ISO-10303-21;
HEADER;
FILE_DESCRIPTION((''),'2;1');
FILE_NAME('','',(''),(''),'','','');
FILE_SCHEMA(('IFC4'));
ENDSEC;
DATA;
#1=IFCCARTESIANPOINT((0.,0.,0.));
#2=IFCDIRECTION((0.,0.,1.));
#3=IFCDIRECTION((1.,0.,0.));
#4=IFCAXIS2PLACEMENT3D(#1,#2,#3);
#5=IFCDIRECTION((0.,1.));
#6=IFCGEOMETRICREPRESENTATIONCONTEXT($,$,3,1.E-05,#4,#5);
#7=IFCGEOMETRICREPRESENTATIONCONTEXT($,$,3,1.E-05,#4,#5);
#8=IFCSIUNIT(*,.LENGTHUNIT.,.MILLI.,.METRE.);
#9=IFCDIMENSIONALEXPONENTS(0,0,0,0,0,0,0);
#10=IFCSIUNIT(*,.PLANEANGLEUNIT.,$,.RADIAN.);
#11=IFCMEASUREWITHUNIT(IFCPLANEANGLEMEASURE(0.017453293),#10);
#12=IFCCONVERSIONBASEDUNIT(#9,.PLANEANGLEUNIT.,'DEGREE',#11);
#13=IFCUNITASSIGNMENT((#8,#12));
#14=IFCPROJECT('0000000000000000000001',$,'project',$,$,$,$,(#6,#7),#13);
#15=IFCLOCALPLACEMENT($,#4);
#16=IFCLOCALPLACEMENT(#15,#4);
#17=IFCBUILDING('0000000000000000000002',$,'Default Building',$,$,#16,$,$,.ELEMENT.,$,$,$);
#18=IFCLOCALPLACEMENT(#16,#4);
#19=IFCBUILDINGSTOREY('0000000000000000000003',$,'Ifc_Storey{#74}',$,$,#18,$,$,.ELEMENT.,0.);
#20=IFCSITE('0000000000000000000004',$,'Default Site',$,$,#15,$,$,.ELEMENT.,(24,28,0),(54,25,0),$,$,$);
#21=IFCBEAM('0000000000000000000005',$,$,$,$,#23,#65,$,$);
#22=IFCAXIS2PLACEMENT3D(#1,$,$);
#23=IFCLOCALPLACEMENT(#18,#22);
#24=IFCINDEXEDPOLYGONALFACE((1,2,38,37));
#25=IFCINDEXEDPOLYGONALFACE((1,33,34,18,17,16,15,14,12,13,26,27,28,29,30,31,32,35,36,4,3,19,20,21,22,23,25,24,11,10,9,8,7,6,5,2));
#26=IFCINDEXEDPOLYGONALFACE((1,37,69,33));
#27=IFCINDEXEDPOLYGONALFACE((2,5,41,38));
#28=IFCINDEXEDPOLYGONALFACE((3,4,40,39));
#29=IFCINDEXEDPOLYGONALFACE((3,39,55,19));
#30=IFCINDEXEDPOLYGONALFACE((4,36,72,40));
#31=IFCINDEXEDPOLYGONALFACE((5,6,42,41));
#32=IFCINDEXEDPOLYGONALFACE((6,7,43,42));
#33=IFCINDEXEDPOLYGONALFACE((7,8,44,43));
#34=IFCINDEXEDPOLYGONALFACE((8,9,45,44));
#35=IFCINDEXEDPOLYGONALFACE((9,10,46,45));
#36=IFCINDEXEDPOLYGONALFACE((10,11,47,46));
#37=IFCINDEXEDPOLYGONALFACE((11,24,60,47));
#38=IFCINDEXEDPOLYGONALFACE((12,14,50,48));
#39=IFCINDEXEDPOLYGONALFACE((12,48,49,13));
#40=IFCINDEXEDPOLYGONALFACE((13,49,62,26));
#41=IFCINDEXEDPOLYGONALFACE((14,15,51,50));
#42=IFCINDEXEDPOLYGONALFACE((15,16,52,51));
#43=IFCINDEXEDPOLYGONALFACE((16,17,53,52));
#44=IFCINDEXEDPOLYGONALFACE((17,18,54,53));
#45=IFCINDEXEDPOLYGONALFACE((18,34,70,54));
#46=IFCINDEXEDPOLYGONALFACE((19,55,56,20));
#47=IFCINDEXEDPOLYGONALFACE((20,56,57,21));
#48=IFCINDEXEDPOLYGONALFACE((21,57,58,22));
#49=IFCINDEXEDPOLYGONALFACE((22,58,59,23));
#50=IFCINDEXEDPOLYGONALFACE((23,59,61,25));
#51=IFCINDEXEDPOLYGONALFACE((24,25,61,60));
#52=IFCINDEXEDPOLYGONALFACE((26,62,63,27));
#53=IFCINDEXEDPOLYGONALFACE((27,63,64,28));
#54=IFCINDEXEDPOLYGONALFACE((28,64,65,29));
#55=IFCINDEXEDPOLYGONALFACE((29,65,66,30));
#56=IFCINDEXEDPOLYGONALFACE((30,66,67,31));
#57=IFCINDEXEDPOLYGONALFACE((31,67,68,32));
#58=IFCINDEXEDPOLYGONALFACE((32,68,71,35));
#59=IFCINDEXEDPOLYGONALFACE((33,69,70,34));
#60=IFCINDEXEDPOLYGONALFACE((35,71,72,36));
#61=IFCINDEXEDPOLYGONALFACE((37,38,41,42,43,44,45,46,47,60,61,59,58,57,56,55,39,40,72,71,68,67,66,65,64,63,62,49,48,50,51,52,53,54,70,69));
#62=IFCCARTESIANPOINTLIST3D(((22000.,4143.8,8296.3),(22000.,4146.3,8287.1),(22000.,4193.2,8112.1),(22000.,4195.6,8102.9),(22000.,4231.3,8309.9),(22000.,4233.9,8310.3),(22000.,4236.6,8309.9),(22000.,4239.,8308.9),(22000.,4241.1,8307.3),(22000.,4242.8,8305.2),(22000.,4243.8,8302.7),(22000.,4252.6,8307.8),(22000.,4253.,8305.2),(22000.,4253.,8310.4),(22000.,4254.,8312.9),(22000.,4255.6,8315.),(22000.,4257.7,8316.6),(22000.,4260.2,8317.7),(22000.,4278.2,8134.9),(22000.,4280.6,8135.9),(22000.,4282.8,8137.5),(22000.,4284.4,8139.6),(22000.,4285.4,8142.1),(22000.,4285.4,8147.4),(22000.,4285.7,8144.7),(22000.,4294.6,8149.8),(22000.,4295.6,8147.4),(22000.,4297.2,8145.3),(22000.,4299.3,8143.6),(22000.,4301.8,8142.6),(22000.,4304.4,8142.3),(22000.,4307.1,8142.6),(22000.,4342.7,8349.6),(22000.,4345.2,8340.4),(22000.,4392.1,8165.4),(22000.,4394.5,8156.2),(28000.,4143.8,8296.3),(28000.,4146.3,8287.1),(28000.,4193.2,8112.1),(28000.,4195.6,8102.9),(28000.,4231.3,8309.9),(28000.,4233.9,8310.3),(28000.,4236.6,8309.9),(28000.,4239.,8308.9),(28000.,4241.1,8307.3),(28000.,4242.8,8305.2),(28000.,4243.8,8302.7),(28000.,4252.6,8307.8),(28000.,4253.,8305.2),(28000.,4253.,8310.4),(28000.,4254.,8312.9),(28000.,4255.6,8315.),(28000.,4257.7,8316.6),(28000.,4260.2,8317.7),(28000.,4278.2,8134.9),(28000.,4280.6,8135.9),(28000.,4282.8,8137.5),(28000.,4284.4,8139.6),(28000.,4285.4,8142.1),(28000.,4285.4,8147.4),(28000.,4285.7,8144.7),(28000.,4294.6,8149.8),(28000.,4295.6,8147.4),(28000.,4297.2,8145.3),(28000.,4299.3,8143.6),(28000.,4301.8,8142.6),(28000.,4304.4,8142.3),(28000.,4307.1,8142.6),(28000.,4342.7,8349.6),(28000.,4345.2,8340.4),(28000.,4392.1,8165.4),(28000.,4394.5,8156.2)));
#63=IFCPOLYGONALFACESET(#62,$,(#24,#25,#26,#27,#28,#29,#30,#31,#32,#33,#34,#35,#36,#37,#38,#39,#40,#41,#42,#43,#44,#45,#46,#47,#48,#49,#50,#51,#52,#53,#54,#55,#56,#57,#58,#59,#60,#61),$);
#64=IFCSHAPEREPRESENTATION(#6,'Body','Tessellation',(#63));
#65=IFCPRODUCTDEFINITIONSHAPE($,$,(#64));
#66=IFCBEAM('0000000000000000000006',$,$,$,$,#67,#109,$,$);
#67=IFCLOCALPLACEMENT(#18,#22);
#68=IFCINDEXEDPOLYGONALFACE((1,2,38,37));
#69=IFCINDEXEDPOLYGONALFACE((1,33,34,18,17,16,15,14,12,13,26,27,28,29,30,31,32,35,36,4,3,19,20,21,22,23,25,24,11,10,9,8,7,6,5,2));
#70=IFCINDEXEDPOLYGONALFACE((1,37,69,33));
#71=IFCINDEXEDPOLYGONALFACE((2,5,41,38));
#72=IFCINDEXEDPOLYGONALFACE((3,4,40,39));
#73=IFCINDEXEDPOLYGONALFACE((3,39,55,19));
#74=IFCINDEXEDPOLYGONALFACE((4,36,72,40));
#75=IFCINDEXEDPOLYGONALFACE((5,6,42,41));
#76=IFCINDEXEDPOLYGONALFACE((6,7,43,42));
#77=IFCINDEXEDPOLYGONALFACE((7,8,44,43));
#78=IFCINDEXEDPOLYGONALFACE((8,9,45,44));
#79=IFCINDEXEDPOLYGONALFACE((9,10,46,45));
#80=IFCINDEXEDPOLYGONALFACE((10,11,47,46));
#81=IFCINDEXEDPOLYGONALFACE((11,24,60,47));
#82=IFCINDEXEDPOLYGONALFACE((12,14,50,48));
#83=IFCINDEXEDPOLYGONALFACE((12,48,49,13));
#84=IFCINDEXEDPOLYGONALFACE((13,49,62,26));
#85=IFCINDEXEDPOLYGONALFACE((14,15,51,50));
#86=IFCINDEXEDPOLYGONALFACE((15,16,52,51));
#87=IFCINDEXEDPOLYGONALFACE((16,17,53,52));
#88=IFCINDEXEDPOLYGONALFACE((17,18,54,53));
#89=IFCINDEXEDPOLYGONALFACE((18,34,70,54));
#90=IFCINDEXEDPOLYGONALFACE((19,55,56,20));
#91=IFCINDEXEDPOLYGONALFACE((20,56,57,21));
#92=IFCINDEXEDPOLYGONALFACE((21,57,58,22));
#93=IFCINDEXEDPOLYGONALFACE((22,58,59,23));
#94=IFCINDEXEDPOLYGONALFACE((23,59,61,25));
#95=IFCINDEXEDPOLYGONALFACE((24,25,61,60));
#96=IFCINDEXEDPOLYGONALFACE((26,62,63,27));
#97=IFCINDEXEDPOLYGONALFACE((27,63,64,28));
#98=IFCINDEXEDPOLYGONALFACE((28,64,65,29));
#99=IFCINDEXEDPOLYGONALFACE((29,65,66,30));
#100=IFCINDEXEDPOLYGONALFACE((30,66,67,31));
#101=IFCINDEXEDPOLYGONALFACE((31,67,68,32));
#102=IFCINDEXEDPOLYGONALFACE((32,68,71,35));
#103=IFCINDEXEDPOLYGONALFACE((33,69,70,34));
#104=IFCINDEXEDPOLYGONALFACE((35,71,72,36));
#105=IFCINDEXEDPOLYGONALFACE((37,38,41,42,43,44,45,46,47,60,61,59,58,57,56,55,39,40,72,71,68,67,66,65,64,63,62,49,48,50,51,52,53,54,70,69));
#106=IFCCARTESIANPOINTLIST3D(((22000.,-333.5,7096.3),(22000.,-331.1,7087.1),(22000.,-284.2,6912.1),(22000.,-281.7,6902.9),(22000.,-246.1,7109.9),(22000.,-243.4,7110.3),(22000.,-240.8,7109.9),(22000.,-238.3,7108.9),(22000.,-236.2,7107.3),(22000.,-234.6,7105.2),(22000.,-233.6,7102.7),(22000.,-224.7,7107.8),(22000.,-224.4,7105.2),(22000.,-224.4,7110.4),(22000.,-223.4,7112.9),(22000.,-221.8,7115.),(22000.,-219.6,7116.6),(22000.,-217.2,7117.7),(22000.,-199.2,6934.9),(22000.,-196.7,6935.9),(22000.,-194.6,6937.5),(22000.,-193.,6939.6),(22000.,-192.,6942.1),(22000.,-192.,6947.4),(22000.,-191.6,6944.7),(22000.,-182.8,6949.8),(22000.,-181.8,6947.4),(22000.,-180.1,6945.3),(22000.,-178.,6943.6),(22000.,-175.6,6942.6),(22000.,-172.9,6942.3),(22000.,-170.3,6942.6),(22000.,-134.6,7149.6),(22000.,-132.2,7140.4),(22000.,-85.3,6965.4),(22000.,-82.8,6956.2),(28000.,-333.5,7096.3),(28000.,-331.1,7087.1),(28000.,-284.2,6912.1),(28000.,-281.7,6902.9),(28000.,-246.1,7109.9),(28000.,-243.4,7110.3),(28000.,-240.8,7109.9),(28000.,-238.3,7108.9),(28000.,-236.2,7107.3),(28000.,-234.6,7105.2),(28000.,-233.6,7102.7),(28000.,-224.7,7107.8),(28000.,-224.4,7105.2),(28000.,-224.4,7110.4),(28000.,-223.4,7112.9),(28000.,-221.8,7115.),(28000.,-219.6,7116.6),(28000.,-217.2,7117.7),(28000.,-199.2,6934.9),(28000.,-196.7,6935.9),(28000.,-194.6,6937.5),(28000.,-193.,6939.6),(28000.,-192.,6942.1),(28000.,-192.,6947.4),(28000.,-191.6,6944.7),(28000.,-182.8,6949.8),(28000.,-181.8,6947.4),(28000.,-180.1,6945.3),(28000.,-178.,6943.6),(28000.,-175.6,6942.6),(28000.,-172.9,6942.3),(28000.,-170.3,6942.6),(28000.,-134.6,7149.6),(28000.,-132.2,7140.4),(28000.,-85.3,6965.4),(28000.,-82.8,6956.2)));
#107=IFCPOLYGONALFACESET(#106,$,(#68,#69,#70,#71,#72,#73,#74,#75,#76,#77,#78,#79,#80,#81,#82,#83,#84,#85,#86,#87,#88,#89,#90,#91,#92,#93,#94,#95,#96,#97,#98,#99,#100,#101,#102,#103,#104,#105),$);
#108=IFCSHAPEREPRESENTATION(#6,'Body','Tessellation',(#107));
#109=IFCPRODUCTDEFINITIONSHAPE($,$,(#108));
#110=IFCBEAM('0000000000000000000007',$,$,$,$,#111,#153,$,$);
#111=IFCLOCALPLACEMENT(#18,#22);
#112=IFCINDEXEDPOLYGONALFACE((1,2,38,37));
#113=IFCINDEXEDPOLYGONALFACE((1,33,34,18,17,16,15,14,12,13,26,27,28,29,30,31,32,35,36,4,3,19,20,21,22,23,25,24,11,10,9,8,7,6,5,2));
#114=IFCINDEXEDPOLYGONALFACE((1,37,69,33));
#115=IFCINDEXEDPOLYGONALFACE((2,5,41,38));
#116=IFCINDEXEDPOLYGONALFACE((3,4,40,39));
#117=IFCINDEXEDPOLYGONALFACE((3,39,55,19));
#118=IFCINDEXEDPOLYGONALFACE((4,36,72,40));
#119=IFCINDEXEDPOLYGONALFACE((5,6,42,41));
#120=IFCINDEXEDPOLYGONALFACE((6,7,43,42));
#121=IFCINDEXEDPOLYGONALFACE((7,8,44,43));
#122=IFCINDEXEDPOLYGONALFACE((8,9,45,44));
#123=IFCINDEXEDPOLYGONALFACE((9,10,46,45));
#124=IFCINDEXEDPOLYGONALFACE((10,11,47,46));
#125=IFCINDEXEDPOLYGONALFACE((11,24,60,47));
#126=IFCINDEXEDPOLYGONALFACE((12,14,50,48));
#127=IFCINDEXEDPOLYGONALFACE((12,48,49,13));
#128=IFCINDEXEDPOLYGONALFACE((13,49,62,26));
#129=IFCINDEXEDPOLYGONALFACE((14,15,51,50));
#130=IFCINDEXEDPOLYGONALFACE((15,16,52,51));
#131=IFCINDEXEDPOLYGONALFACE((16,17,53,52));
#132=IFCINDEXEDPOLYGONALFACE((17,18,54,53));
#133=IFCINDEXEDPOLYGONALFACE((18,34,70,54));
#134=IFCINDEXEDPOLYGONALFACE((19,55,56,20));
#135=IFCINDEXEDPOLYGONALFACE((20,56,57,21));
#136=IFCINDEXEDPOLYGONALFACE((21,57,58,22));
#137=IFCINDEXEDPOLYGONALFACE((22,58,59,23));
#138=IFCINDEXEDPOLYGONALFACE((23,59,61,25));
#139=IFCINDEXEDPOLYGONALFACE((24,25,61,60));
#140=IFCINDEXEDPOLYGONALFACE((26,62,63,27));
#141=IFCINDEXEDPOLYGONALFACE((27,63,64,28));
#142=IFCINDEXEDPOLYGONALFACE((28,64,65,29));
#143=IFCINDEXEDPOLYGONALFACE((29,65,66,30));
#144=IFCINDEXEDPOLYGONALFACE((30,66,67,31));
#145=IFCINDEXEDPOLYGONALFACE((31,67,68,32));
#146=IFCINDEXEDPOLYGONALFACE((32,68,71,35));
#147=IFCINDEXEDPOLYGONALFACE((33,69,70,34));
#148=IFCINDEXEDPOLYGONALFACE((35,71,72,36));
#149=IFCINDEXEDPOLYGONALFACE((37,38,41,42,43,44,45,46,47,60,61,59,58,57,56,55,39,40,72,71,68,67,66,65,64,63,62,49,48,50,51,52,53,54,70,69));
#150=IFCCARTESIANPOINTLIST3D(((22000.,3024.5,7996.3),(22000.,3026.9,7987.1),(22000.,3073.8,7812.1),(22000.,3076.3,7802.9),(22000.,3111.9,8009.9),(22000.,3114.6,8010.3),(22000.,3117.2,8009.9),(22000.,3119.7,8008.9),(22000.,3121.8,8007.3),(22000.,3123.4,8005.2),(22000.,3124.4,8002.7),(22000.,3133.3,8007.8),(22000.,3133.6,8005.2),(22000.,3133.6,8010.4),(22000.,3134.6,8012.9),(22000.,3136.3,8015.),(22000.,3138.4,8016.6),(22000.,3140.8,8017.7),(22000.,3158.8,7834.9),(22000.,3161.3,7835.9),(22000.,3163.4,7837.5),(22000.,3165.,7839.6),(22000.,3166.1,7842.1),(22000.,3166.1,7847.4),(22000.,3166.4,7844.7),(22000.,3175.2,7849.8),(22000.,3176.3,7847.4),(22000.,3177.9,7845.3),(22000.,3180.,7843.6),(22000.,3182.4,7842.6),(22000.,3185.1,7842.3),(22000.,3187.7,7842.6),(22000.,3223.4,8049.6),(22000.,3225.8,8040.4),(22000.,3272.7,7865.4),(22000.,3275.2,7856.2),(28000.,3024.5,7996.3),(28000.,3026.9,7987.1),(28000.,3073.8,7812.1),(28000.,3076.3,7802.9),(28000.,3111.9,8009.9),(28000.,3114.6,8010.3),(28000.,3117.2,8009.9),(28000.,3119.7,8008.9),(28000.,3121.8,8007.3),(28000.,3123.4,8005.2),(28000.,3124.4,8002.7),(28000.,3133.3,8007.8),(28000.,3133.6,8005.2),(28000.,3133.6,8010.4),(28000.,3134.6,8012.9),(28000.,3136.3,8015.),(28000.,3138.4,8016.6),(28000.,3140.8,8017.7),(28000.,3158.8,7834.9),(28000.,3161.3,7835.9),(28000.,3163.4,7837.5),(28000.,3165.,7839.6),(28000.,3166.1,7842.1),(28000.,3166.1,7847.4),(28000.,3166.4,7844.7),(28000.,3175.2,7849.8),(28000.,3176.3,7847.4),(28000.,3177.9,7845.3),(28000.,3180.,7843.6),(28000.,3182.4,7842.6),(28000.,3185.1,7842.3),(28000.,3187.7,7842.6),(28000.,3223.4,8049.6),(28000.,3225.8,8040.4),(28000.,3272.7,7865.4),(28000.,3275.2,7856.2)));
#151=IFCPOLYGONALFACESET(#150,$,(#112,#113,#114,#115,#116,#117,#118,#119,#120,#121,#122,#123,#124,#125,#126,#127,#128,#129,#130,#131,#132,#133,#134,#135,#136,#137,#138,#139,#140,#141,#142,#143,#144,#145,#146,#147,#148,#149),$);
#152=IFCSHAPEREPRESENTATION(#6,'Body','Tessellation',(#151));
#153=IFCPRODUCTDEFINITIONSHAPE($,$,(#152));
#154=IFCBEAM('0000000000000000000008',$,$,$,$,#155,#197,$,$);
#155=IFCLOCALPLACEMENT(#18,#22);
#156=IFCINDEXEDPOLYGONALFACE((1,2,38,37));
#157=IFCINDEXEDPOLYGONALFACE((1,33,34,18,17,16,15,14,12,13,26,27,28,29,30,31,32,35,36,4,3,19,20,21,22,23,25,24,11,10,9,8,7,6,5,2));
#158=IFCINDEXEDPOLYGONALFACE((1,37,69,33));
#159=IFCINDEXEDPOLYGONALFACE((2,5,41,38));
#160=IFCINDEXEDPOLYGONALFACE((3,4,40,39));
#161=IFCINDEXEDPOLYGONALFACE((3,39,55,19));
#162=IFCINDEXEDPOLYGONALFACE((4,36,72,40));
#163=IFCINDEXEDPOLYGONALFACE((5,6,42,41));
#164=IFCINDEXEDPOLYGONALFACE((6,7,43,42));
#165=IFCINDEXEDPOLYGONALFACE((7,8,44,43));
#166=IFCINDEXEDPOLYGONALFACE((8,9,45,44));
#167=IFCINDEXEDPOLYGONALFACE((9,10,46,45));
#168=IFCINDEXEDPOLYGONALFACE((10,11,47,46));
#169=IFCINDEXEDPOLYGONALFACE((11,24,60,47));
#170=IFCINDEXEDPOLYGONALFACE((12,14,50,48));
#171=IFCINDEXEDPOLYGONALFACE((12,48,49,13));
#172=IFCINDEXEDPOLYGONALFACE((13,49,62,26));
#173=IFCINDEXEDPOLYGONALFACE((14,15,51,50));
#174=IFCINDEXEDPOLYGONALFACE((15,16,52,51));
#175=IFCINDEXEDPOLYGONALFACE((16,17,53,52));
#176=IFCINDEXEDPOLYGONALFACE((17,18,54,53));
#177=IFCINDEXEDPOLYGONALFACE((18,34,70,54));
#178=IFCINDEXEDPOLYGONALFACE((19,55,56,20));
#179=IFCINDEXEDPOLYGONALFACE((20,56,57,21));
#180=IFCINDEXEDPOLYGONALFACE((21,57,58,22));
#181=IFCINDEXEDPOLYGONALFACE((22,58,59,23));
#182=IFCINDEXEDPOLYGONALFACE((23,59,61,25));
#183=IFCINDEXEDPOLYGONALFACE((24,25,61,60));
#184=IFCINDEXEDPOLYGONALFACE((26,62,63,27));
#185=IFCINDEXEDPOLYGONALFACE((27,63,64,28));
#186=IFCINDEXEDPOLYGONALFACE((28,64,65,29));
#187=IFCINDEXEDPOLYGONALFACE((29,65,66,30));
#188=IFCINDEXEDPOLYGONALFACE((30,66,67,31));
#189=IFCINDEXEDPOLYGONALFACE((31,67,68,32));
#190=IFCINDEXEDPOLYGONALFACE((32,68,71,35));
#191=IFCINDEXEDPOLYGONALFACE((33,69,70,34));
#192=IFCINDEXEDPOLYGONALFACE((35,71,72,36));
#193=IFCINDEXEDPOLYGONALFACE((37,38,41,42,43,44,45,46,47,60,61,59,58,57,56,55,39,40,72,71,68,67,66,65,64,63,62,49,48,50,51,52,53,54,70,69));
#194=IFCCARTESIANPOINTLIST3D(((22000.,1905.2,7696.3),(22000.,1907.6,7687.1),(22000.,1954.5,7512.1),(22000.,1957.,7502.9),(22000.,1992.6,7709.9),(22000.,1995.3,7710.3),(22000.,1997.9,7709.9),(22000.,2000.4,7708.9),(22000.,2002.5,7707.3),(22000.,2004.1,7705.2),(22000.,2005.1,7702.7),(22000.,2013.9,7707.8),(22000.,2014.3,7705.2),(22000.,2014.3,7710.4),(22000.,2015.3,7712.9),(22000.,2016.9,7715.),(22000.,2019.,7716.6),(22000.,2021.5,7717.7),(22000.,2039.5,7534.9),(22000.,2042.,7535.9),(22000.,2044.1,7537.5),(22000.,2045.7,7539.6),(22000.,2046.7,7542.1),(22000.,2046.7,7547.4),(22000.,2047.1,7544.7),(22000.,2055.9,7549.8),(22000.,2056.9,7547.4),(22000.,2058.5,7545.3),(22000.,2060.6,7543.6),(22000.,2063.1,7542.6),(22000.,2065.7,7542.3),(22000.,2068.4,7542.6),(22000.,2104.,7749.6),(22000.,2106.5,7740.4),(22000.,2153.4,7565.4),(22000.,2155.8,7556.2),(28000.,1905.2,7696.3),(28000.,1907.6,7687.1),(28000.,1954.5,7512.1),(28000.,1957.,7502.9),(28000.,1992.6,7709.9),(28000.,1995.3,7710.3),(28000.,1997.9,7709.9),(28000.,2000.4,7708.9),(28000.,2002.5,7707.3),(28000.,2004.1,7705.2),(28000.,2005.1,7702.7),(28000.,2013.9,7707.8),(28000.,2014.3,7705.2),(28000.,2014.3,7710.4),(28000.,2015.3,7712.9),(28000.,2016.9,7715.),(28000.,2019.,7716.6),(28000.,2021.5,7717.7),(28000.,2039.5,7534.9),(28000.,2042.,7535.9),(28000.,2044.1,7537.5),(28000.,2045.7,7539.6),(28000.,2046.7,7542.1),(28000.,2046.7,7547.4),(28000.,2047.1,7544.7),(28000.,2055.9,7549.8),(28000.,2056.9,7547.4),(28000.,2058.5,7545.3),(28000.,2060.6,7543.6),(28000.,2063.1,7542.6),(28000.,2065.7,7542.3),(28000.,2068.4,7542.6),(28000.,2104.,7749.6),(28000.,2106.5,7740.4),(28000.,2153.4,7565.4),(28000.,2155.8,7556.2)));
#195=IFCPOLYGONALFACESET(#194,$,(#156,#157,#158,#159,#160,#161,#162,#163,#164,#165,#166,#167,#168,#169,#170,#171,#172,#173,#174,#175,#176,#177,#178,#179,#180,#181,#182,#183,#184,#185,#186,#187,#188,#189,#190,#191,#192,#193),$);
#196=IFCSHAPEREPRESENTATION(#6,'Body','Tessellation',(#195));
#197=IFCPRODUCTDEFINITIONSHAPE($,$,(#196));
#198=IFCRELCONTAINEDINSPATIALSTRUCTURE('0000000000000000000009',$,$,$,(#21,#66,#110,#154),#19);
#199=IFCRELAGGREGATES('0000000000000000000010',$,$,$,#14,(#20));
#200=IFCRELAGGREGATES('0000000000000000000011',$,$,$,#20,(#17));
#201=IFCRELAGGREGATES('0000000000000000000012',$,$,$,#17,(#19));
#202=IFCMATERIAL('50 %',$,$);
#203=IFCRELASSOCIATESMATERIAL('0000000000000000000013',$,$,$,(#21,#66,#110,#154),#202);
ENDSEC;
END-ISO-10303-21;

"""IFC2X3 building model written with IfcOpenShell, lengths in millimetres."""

from ifc_helpers import new_model, entity, si_unit, converted_unit, direction, frame, origin_with_axes, origin_2d_with_axis, place, context, project, spatial, i_section, extrude, material, element, save


model = new_model("IFC2X3")

# Units and contexts
context_of_model_1 = context(None, 3, precision=1e-05, world=origin_with_axes(), true_north=direction((0.0, 1.0)))
context_of_model_2 = context(None, 3, precision=1e-05, world=origin_with_axes(), true_north=direction((0.0, 1.0)))
ifc_project = project(units=[si_unit("LENGTHUNIT", "METRE", prefix="MILLI"), converted_unit("PLANEANGLEUNIT", "DEGREE", entity("IfcPlaneAngleMeasure", 0.017453293), si_unit("PLANEANGLEUNIT", "RADIAN"), dimensions=[0, 0, 0, 0, 0, 0, 0])], contexts=[context_of_model_1, context_of_model_2])

# Site, building, storey
site_placement = place(None, origin_with_axes())
site = spatial("IfcSite", under=ifc_project, at=site_placement, Name="Default Site", CompositionType="ELEMENT", RefLatitude=(24, 28, 0), RefLongitude=(54, 25, 0))
building_placement = place(site_placement, origin_with_axes())
building = spatial("IfcBuilding", under=site, at=building_placement, Name="Default Building", CompositionType="ELEMENT")
storey_placement = place(building_placement, origin_with_axes())
storey = spatial("IfcBuildingStorey", under=building, at=storey_placement, Name="Ifc_Storey{#74}", CompositionType="ELEMENT", Elevation=0.0)

# Shared definitions
ifc_material_1 = material(Name="50 %")

# Beams
for number, where, z_axis, x_axis in (
    (1, (22000.0, 4269.2, 8226.3), (0.0, -0.258819, 0.965926), (-1.0, 0.0, 0.0)),
    (2, (22000.0, -208.2, 7026.3), (0.0, -0.258819, 0.965926), (-1.0, 0.0, 0.0)),
    (3, (22000.0, 3149.8, 7926.3), (0.0, -0.258819, 0.965926), (-1.0, 0.0, 0.0)),
    (4, (22000.0, 2030.5, 7626.3), (0.0, -0.258819, 0.965926), (-1.0, 0.0, 0.0)),
):
    element("IfcBeam", number, at=place(storey_placement, frame(where, z_axis=z_axis, x_axis=x_axis)), inside=storey, material=ifc_material_1, context=context_of_model_1, shape_type="SweptSolid", body=[
        extrude(i_section(OverallWidth=205.9, OverallDepth=200.2, WebThickness=9.5, FlangeThickness=9.5, FilletRadius=10.2, at=origin_2d_with_axis()), frame((0.0, 0.0, 0.0), z_axis=(-1.0, 0.0, 0.0), x_axis=(0.0, 1.0, 0.0)), (0.0, 0.0, 1.0), 6000.0),
    ])

save(model, "model.ifc")
